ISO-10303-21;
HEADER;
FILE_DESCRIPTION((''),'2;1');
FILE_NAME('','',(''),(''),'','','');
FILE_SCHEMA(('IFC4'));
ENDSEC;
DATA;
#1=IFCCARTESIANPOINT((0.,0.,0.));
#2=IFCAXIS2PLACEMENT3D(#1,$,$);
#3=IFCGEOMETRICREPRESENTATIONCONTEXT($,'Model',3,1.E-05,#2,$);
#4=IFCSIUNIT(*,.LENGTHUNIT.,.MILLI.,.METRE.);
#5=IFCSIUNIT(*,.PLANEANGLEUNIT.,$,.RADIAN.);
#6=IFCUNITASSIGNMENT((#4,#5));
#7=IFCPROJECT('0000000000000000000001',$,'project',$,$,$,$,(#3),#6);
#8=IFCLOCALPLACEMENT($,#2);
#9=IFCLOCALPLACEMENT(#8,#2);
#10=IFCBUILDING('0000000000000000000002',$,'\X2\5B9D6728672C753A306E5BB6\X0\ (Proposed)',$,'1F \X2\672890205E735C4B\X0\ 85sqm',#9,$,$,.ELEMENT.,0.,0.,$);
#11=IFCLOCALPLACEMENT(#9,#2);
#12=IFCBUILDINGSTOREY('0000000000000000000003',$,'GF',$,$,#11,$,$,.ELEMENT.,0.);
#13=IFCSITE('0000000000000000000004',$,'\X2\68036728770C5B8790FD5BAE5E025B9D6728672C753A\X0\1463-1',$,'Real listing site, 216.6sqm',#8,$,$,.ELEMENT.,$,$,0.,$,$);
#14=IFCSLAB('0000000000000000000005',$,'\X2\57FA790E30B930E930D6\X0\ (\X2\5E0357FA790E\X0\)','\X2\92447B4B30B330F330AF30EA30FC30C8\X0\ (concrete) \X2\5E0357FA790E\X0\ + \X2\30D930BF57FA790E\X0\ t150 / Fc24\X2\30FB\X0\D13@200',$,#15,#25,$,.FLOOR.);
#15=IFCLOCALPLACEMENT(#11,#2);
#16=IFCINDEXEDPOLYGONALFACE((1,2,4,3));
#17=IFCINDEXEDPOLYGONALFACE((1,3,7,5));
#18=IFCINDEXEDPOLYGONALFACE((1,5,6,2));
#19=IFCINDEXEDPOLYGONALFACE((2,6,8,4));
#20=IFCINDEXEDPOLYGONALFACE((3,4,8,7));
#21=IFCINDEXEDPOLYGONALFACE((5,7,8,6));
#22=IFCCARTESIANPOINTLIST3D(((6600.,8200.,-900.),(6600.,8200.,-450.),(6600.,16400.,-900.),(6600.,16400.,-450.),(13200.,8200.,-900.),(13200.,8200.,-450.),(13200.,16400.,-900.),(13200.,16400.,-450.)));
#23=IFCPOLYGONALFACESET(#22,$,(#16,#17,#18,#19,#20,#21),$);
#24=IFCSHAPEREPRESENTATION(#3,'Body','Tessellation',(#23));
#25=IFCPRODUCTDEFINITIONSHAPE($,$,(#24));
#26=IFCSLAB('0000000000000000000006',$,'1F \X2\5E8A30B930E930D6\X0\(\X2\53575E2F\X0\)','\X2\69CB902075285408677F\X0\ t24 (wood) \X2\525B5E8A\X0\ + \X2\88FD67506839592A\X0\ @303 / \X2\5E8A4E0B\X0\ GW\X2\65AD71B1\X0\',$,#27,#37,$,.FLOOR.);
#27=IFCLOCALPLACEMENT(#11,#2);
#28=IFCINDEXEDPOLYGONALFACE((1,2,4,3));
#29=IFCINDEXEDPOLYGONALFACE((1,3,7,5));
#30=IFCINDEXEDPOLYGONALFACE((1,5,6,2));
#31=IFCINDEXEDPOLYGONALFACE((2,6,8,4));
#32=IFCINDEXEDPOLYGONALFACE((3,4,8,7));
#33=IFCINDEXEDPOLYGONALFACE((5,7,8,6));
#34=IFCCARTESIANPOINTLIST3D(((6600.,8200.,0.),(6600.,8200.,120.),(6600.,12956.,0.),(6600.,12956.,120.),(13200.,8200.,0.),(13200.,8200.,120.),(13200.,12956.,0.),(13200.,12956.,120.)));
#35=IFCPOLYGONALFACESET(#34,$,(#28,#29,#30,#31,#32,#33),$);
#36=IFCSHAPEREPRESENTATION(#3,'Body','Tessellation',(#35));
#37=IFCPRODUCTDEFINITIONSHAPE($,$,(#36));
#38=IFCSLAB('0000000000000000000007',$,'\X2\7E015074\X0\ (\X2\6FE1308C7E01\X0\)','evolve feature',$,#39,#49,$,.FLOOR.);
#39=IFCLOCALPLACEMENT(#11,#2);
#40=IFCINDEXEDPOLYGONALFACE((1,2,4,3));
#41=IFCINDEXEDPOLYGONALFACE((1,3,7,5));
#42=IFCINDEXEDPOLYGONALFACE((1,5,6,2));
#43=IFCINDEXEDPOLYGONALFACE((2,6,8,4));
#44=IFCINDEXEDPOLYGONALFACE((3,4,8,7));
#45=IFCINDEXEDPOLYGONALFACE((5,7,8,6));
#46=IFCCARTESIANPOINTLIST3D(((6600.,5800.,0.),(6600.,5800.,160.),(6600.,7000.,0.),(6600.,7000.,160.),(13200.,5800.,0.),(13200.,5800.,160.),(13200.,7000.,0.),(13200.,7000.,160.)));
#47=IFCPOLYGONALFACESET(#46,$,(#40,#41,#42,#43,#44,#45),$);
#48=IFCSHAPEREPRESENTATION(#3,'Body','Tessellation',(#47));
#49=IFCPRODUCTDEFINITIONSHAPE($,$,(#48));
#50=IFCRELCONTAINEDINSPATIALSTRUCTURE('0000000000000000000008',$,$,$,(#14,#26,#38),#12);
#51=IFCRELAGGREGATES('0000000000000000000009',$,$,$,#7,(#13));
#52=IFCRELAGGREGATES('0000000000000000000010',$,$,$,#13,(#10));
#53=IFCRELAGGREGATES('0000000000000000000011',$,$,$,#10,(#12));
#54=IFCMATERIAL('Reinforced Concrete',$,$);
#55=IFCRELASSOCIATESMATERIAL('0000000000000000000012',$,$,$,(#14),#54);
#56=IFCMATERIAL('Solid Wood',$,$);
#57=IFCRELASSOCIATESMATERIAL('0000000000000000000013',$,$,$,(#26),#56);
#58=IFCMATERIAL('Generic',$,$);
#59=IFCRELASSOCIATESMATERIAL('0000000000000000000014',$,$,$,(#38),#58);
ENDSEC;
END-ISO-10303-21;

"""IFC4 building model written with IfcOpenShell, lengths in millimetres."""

from ifc_helpers import new_model, si_unit, frame, frame_2d, origin, place, context, project, spatial, rectangle, extrude, material, element, save


model = new_model("IFC4")

# Units and contexts
model_context = context("Model", 3, precision=1e-05, world=origin())
ifc_project = project(units=[si_unit("LENGTHUNIT", "METRE", prefix="MILLI"), si_unit("PLANEANGLEUNIT", "RADIAN")], contexts=[model_context])

# Site, building, storey
site_placement = place(None, origin())
site = spatial("IfcSite", under=ifc_project, at=site_placement, Name="栃木県宇都宮市宝木本町1463-1", ObjectType="Real listing site, 216.6sqm", CompositionType="ELEMENT", RefElevation=0.0)
building_placement = place(site_placement, origin())
building = spatial("IfcBuilding", under=site, at=building_placement, Name="宝木本町の家 (Proposed)", ObjectType="1F 木造平屋 85sqm", CompositionType="ELEMENT", ElevationOfRefHeight=0.0, ElevationOfTerrain=0.0)
storey_placement = place(building_placement, origin())
storey = spatial("IfcBuildingStorey", under=building, at=storey_placement, Name="GF", CompositionType="ELEMENT", Elevation=0.0)

# Slabs
ifc_material_1 = material(Name="Reinforced Concrete")
slab_1_placement = place(storey_placement, frame((3300.0, 4100.0, -450.0)))
element("IfcSlab", 1, at=slab_1_placement, inside=storey, material=ifc_material_1, Name="基礎スラブ (布基礎)", Description="鉄筋コンクリート (concrete) 布基礎 + ベタ基礎 t150 / Fc24・D13@200", PredefinedType="FLOOR", context=model_context, shape_type="SweptSolid", body=[
    extrude(rectangle(XDim=6600.0, YDim=8200.0, at=frame_2d((3300.0, 4100.0))), frame((3300.0, 4100.0, -450.0)), (0.0, 0.0, 1.0), 450.0),
])
ifc_material_2 = material(Name="Solid Wood")
slab_2_placement = place(storey_placement, frame((3300.0, 4100.0, 0.0)))
element("IfcSlab", 2, at=slab_2_placement, inside=storey, material=ifc_material_2, Name="1F 床スラブ(南帯)", Description="構造用合板 t24 (wood) 剛床 + 製材根太 @303 / 床下 GW断熱", PredefinedType="FLOOR", context=model_context, shape_type="SweptSolid", body=[
    extrude(rectangle(XDim=6600.0, YDim=4756.0, at=frame_2d((3300.0, 2378.0))), frame((3300.0, 4100.0, 0.0)), (0.0, 0.0, 1.0), 120.0),
])
ifc_material_3 = material(Name="Generic")
slab_3_placement = place(storey_placement, frame((3300.0, 2900.0, 0.0)))
element("IfcSlab", 3, at=slab_3_placement, inside=storey, material=ifc_material_3, Name="縁側 (濡れ縁)", Description="evolve feature", PredefinedType="FLOOR", context=model_context, shape_type="SweptSolid", body=[
    extrude(rectangle(XDim=6600.0, YDim=1200.0, at=frame_2d((3300.0, 600.0))), frame((3300.0, 2900.0, 0.0)), (0.0, 0.0, 1.0), 160.0),
])

save(model, "model.ifc")
